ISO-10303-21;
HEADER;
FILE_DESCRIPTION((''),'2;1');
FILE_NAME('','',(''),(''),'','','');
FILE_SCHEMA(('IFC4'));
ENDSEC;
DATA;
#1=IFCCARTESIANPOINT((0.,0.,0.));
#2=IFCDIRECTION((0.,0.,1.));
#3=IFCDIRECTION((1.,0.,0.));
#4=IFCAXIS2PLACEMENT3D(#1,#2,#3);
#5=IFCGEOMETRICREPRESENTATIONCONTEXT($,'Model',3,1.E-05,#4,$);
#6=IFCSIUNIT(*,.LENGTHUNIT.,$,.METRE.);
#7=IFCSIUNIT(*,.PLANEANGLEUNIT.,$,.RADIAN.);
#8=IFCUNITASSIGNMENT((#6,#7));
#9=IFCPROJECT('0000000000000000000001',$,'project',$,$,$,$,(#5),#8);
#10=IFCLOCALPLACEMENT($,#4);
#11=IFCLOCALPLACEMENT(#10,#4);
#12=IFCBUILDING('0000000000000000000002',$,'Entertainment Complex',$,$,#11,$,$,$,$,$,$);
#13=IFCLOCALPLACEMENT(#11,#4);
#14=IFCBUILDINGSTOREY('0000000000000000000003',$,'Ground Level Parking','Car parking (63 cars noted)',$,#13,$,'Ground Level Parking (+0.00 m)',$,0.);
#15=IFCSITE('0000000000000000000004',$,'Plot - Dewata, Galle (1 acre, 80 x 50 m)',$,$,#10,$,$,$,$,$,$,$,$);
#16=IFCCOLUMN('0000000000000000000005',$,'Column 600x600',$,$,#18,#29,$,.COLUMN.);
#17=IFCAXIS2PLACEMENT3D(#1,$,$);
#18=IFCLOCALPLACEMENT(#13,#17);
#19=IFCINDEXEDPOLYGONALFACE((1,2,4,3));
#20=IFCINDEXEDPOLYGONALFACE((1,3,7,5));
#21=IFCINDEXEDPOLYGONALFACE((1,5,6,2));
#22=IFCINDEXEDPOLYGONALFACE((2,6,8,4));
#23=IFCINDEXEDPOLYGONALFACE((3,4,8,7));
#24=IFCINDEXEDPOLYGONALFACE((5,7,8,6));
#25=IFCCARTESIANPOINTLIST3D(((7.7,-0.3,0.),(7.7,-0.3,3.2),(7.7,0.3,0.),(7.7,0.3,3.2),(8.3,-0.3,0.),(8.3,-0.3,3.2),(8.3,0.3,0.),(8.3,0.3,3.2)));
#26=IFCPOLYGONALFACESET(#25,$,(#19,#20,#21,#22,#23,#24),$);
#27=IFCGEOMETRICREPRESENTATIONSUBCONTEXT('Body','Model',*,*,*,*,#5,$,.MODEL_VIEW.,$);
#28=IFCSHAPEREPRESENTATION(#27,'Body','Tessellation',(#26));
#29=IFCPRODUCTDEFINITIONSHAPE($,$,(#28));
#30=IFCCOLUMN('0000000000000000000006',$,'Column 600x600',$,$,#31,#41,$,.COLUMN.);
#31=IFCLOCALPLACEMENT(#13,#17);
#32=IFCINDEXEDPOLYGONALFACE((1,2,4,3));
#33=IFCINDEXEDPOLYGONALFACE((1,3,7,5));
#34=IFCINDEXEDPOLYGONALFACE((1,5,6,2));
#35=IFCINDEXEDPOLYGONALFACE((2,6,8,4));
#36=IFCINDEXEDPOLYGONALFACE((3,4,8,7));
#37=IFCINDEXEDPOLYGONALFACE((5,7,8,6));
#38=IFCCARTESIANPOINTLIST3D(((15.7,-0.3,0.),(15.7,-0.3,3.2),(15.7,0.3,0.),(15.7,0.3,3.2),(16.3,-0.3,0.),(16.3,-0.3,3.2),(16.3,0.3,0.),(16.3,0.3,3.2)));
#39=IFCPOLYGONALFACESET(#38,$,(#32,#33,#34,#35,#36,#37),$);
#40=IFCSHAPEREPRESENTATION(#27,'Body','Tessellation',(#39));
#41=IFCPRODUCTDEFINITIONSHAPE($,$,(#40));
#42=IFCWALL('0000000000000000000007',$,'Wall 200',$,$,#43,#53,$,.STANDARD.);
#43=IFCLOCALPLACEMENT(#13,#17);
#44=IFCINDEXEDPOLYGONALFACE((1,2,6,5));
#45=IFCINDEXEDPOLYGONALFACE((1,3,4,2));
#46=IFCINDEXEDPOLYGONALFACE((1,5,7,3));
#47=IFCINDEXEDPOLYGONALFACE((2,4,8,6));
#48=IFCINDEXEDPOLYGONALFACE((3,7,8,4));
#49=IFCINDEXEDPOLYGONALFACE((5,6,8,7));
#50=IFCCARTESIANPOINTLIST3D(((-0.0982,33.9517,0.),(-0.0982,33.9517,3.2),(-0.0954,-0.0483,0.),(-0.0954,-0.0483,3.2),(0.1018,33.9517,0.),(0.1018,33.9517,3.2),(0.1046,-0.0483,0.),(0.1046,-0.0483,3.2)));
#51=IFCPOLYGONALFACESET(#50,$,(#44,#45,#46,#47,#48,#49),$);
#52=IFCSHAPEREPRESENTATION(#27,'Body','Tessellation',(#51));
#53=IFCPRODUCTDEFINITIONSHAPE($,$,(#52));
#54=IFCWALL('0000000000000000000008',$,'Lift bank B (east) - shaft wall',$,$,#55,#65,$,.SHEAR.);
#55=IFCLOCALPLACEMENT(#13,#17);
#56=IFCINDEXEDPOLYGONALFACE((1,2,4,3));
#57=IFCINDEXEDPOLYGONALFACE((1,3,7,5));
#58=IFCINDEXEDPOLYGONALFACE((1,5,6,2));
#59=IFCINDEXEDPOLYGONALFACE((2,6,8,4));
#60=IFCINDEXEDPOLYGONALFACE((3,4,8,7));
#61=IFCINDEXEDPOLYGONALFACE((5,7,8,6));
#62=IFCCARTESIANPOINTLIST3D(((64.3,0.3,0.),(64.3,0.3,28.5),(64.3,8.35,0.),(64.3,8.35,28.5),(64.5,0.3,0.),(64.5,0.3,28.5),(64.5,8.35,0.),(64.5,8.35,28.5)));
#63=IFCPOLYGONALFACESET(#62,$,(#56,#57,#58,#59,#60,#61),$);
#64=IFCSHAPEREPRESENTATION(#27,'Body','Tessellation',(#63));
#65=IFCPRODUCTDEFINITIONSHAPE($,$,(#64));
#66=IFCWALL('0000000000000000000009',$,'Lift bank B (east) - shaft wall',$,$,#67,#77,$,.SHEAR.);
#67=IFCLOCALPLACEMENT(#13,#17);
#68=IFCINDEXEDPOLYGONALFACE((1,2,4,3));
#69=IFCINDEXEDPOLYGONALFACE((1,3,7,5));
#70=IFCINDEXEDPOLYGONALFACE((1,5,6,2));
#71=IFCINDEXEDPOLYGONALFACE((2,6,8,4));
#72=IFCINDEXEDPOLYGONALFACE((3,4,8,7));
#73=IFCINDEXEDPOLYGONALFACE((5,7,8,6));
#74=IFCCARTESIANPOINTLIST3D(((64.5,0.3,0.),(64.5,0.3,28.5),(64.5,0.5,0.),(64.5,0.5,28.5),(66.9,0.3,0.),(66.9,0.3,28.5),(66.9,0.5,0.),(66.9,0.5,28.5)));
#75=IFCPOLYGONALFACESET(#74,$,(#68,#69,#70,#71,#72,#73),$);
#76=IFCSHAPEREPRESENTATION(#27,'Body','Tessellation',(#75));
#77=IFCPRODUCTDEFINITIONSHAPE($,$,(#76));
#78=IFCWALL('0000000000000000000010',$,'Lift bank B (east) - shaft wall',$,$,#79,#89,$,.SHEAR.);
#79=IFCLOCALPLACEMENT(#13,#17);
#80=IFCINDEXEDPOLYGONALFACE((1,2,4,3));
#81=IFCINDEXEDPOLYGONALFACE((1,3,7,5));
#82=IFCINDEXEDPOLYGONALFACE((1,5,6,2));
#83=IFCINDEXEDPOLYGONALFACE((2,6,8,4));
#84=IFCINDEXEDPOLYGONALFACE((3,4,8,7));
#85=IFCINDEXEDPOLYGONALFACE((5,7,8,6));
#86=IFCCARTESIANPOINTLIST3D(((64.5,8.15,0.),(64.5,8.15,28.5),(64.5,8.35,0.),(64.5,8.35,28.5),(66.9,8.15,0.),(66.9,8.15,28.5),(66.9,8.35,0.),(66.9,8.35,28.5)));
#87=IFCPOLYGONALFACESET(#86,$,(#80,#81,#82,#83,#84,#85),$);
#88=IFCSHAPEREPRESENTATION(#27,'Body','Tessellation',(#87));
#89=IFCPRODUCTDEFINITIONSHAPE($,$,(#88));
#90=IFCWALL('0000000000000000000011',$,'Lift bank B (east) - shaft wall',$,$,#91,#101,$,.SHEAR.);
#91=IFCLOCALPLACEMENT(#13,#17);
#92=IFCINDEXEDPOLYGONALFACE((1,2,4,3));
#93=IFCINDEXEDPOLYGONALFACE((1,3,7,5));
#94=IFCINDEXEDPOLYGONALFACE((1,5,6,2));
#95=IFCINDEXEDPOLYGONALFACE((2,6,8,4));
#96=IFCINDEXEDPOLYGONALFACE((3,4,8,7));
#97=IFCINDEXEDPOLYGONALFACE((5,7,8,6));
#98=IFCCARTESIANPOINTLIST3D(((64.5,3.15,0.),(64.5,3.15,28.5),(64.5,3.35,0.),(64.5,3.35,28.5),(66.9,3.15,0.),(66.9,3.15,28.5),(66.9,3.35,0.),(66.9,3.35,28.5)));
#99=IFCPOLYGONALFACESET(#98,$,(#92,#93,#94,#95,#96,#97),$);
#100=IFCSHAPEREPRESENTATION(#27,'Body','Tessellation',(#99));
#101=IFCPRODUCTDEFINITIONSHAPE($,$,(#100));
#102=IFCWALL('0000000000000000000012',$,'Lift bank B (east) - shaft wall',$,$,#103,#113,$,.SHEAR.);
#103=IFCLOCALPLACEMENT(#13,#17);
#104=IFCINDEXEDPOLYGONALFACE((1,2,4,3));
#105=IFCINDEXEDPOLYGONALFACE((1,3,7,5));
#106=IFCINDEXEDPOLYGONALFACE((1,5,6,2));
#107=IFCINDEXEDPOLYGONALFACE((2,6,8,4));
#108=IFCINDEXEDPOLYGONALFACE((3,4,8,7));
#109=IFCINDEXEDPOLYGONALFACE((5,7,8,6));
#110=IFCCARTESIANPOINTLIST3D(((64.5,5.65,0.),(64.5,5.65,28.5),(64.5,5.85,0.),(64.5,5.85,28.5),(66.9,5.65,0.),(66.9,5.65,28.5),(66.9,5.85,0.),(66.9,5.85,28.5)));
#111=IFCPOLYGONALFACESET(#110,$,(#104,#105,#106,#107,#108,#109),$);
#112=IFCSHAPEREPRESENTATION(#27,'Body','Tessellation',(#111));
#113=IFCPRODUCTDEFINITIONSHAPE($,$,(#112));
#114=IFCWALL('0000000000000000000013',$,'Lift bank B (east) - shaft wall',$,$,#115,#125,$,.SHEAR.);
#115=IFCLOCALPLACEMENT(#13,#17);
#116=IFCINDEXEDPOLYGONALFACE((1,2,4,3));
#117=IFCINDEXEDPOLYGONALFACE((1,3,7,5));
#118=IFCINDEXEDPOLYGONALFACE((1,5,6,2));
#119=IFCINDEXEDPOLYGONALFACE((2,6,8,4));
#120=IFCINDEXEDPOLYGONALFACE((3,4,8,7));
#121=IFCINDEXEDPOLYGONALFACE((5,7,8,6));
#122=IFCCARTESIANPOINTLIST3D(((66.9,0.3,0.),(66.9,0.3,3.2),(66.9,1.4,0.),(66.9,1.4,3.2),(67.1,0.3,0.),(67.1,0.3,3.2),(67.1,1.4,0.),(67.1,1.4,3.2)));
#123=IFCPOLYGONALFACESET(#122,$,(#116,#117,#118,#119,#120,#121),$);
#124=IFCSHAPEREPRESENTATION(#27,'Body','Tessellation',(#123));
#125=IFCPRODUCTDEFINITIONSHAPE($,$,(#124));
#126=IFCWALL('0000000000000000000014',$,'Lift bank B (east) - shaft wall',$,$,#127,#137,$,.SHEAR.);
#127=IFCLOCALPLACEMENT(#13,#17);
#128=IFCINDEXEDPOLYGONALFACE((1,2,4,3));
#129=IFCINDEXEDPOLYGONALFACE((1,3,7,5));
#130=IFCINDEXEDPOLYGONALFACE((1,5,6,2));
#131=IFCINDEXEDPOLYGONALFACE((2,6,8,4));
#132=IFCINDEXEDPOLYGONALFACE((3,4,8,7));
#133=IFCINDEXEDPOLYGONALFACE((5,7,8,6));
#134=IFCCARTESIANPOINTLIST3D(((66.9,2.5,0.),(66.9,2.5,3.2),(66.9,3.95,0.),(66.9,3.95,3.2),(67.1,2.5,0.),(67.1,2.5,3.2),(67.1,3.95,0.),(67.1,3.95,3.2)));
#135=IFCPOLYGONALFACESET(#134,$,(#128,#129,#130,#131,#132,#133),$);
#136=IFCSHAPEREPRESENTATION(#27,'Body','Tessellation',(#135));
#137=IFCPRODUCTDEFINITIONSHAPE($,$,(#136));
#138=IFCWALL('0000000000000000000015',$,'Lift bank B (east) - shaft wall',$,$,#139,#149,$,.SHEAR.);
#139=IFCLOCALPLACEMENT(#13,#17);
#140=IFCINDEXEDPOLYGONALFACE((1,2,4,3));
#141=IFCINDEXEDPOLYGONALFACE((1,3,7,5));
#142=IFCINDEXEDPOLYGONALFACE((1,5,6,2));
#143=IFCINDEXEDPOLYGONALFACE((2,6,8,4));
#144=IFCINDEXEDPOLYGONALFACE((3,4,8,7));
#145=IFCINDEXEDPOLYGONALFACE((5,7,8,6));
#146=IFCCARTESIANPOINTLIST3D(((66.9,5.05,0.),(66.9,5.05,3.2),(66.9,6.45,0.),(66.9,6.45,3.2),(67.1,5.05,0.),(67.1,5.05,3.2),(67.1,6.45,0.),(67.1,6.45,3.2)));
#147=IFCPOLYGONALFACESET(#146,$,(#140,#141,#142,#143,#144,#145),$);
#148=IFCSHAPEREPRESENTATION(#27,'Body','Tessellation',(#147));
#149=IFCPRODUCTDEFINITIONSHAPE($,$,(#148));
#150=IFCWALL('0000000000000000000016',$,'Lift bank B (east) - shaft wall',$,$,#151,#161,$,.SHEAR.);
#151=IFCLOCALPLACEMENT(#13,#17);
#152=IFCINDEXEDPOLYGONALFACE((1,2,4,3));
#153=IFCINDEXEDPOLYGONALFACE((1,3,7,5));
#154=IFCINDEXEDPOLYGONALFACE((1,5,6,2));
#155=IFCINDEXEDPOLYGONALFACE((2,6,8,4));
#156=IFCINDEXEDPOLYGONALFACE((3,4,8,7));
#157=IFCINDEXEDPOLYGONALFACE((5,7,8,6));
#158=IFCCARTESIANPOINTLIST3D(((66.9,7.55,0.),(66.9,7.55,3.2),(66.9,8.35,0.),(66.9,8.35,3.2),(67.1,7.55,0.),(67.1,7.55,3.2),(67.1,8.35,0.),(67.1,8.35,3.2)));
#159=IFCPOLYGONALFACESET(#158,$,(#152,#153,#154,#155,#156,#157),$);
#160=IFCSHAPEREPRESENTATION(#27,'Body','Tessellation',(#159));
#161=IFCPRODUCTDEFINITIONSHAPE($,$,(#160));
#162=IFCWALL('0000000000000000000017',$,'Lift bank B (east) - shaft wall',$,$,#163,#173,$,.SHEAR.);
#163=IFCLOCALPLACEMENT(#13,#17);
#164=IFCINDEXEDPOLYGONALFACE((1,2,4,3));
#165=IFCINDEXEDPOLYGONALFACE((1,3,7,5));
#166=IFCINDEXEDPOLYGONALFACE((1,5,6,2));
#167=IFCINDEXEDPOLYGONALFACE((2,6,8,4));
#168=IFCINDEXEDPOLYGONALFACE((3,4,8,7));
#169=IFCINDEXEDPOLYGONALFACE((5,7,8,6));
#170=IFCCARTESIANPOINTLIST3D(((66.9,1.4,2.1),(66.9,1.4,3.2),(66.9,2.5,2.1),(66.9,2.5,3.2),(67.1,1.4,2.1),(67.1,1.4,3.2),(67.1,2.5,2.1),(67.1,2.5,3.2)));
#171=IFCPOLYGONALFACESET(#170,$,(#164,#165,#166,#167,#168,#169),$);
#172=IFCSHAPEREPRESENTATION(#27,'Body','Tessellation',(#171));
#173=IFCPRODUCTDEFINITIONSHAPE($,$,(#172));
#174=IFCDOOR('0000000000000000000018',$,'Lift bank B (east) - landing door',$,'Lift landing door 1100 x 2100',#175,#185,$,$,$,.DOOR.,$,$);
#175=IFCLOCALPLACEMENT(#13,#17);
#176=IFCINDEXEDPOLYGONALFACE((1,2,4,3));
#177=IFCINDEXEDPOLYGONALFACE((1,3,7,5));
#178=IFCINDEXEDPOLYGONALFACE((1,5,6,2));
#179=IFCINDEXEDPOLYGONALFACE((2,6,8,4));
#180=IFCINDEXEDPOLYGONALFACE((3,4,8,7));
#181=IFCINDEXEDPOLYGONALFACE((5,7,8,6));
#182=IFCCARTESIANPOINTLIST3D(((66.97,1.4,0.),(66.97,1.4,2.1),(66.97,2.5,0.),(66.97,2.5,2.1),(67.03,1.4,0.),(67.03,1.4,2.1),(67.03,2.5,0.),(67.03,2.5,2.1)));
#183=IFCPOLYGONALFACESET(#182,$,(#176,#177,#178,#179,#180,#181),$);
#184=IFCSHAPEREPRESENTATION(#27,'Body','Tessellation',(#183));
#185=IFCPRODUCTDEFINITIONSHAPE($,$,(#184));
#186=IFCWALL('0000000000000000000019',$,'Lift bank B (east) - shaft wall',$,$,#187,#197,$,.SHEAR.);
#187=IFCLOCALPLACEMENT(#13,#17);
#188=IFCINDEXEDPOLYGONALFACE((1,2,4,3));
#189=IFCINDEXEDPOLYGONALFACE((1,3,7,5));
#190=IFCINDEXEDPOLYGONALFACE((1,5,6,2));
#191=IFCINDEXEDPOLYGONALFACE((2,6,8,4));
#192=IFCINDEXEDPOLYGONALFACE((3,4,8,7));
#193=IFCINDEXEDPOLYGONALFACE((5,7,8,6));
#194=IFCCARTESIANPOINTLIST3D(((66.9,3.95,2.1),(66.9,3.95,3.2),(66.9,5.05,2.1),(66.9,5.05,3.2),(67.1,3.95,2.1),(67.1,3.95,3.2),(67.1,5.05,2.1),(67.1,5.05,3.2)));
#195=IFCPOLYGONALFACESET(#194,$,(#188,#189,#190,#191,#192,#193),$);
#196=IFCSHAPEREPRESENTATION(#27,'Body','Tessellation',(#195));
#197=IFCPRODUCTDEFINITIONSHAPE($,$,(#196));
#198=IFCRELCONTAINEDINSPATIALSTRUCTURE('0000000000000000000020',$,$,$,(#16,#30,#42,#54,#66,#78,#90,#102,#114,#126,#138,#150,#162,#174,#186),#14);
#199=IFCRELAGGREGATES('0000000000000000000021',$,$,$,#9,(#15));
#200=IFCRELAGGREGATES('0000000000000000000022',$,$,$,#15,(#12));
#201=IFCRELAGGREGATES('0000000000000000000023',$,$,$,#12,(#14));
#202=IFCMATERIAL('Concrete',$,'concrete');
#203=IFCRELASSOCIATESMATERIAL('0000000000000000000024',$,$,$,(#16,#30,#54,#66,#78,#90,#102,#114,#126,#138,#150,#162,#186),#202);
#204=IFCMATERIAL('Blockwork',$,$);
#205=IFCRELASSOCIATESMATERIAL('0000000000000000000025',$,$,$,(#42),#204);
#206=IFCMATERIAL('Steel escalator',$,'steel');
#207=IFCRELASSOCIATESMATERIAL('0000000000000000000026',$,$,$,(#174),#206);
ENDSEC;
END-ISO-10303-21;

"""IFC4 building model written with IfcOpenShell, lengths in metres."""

from ifc_helpers import new_model, si_unit, frame, origin_with_axes, place, context, subcontext, project, spatial, polyline, outline, extrude, material, element, save


model = new_model("IFC4")

# Units and contexts
model_context = context("Model", 3, precision=1e-05, world=origin_with_axes())
body_context = subcontext(model_context, "Body", "Model", "MODEL_VIEW")
ifc_project = project(units=[si_unit("LENGTHUNIT", "METRE"), si_unit("PLANEANGLEUNIT", "RADIAN")], contexts=[model_context])

# Site, building, storey
site_placement = place(None, origin_with_axes())
site = spatial("IfcSite", under=ifc_project, at=site_placement, Name="Plot - Dewata, Galle (1 acre, 80 x 50 m)")
building_placement = place(site_placement, origin_with_axes())
building = spatial("IfcBuilding", under=site, at=building_placement, Name="Entertainment Complex")
storey_placement = place(building_placement, origin_with_axes())
storey = spatial("IfcBuildingStorey", under=building, at=storey_placement, Name="Ground Level Parking", Description="Car parking (63 cars noted)", LongName="Ground Level Parking (+0.00 m)", Elevation=0.0)

# Columns
ifc_material_1 = material(Name="Concrete", Category="concrete")
for number, where, z_axis, x_axis, name in (
    (1, (8.0, 0.0, 0.0), (0.0, 0.0, 1.0), (1.0, 0.0, 0.0), "Column 600x600"),
    (2, (16.0, 0.0, 0.0), (0.0, 0.0, 1.0), (1.0, 0.0, 0.0), "Column 600x600"),
):
    element("IfcColumn", number, at=place(storey_placement, frame(where, z_axis=z_axis, x_axis=x_axis)), inside=storey, material=ifc_material_1, Name=name, PredefinedType="COLUMN", context=body_context, shape_type="SweptSolid", body=[
        extrude(outline(polyline([(-0.3, -0.3), (0.3, -0.3), (0.3, 0.3), (-0.3, 0.3), (-0.3, -0.3)])), origin_with_axes(), (0.0, 0.0, 1.0), 3.2),
    ])

# Walls
ifc_material_2 = material(Name="Blockwork")
wall_1_placement = place(storey_placement, frame((0.0046, -0.0483, 0.0), z_axis=(0.0, 0.0, 1.0), x_axis=(-0.000082, 1.0, 0.0)))
element("IfcWall", 3, at=wall_1_placement, inside=storey, material=ifc_material_2, Name="Wall 200", PredefinedType="STANDARD", context=body_context, shape_type="SweptSolid", body=[
    extrude(outline(polyline([(0.0, -0.1), (34.0, -0.1), (34.0, 0.1), (0.0, 0.1), (0.0, -0.1)])), origin_with_axes(), (0.0, 0.0, 1.0), 3.2),
])
wall_2_placement = place(storey_placement, origin_with_axes())
element("IfcWall", 4, at=wall_2_placement, inside=storey, material=ifc_material_1, Name="Lift bank B (east) - shaft wall", PredefinedType="SHEAR", context=body_context, shape_type="SweptSolid", body=[
    extrude(outline(polyline([(64.3, 0.3), (64.5, 0.3), (64.5, 8.35), (64.3, 8.35), (64.3, 0.3)])), origin_with_axes(), (0.0, 0.0, 1.0), 28.5),
])
wall_3_placement = place(storey_placement, origin_with_axes())
element("IfcWall", 5, at=wall_3_placement, inside=storey, material=ifc_material_1, Name="Lift bank B (east) - shaft wall", PredefinedType="SHEAR", context=body_context, shape_type="SweptSolid", body=[
    extrude(outline(polyline([(64.5, 0.3), (66.9, 0.3), (66.9, 0.5), (64.5, 0.5), (64.5, 0.3)])), origin_with_axes(), (0.0, 0.0, 1.0), 28.5),
])
wall_4_placement = place(storey_placement, origin_with_axes())
element("IfcWall", 6, at=wall_4_placement, inside=storey, material=ifc_material_1, Name="Lift bank B (east) - shaft wall", PredefinedType="SHEAR", context=body_context, shape_type="SweptSolid", body=[
    extrude(outline(polyline([(64.5, 8.15), (66.9, 8.15), (66.9, 8.35), (64.5, 8.35), (64.5, 8.15)])), origin_with_axes(), (0.0, 0.0, 1.0), 28.5),
])
wall_5_placement = place(storey_placement, origin_with_axes())
element("IfcWall", 7, at=wall_5_placement, inside=storey, material=ifc_material_1, Name="Lift bank B (east) - shaft wall", PredefinedType="SHEAR", context=body_context, shape_type="SweptSolid", body=[
    extrude(outline(polyline([(64.5, 3.15), (66.9, 3.15), (66.9, 3.35), (64.5, 3.35), (64.5, 3.15)])), origin_with_axes(), (0.0, 0.0, 1.0), 28.5),
])
wall_6_placement = place(storey_placement, origin_with_axes())
element("IfcWall", 8, at=wall_6_placement, inside=storey, material=ifc_material_1, Name="Lift bank B (east) - shaft wall", PredefinedType="SHEAR", context=body_context, shape_type="SweptSolid", body=[
    extrude(outline(polyline([(64.5, 5.65), (66.9, 5.65), (66.9, 5.85), (64.5, 5.85), (64.5, 5.65)])), origin_with_axes(), (0.0, 0.0, 1.0), 28.5),
])
wall_7_placement = place(storey_placement, origin_with_axes())
element("IfcWall", 9, at=wall_7_placement, inside=storey, material=ifc_material_1, Name="Lift bank B (east) - shaft wall", PredefinedType="SHEAR", context=body_context, shape_type="SweptSolid", body=[
    extrude(outline(polyline([(66.9, 0.3), (67.1, 0.3), (67.1, 1.4), (66.9, 1.4), (66.9, 0.3)])), origin_with_axes(), (0.0, 0.0, 1.0), 3.2),
])
wall_8_placement = place(storey_placement, origin_with_axes())
element("IfcWall", 10, at=wall_8_placement, inside=storey, material=ifc_material_1, Name="Lift bank B (east) - shaft wall", PredefinedType="SHEAR", context=body_context, shape_type="SweptSolid", body=[
    extrude(outline(polyline([(66.9, 2.5), (67.1, 2.5), (67.1, 3.95), (66.9, 3.95), (66.9, 2.5)])), origin_with_axes(), (0.0, 0.0, 1.0), 3.2),
])
wall_9_placement = place(storey_placement, origin_with_axes())
element("IfcWall", 11, at=wall_9_placement, inside=storey, material=ifc_material_1, Name="Lift bank B (east) - shaft wall", PredefinedType="SHEAR", context=body_context, shape_type="SweptSolid", body=[
    extrude(outline(polyline([(66.9, 5.05), (67.1, 5.05), (67.1, 6.45), (66.9, 6.45), (66.9, 5.05)])), origin_with_axes(), (0.0, 0.0, 1.0), 3.2),
])
wall_10_placement = place(storey_placement, origin_with_axes())
element("IfcWall", 12, at=wall_10_placement, inside=storey, material=ifc_material_1, Name="Lift bank B (east) - shaft wall", PredefinedType="SHEAR", context=body_context, shape_type="SweptSolid", body=[
    extrude(outline(polyline([(66.9, 7.55), (67.1, 7.55), (67.1, 8.35), (66.9, 8.35), (66.9, 7.55)])), origin_with_axes(), (0.0, 0.0, 1.0), 3.2),
])
wall_11_placement = place(storey_placement, origin_with_axes())
element("IfcWall", 13, at=wall_11_placement, inside=storey, material=ifc_material_1, Name="Lift bank B (east) - shaft wall", PredefinedType="SHEAR", context=body_context, shape_type="SweptSolid", body=[
    extrude(outline(polyline([(66.9, 1.4), (67.1, 1.4), (67.1, 2.5), (66.9, 2.5), (66.9, 1.4)])), frame((0.0, 0.0, 2.1), z_axis=(0.0, 0.0, 1.0), x_axis=(1.0, 0.0, 0.0)), (0.0, 0.0, 1.0), 1.1),
])

# Door
ifc_material_3 = material(Name="Steel escalator", Category="steel")
door_1_placement = place(storey_placement, origin_with_axes())
element("IfcDoor", 14, at=door_1_placement, inside=storey, material=ifc_material_3, Name="Lift bank B (east) - landing door", ObjectType="Lift landing door 1100 x 2100", PredefinedType="DOOR", context=body_context, shape_type="SweptSolid", body=[
    extrude(outline(polyline([(66.97, 1.4), (67.03, 1.4), (67.03, 2.5), (66.97, 2.5), (66.97, 1.4)])), origin_with_axes(), (0.0, 0.0, 1.0), 2.1),
])

# Wall
wall_12_placement = place(storey_placement, origin_with_axes())
element("IfcWall", 15, at=wall_12_placement, inside=storey, material=ifc_material_1, Name="Lift bank B (east) - shaft wall", PredefinedType="SHEAR", context=body_context, shape_type="SweptSolid", body=[
    extrude(outline(polyline([(66.9, 3.95), (67.1, 3.95), (67.1, 5.05), (66.9, 5.05), (66.9, 3.95)])), frame((0.0, 0.0, 2.1), z_axis=(0.0, 0.0, 1.0), x_axis=(1.0, 0.0, 0.0)), (0.0, 0.0, 1.0), 1.1),
])

save(model, "model.ifc")
